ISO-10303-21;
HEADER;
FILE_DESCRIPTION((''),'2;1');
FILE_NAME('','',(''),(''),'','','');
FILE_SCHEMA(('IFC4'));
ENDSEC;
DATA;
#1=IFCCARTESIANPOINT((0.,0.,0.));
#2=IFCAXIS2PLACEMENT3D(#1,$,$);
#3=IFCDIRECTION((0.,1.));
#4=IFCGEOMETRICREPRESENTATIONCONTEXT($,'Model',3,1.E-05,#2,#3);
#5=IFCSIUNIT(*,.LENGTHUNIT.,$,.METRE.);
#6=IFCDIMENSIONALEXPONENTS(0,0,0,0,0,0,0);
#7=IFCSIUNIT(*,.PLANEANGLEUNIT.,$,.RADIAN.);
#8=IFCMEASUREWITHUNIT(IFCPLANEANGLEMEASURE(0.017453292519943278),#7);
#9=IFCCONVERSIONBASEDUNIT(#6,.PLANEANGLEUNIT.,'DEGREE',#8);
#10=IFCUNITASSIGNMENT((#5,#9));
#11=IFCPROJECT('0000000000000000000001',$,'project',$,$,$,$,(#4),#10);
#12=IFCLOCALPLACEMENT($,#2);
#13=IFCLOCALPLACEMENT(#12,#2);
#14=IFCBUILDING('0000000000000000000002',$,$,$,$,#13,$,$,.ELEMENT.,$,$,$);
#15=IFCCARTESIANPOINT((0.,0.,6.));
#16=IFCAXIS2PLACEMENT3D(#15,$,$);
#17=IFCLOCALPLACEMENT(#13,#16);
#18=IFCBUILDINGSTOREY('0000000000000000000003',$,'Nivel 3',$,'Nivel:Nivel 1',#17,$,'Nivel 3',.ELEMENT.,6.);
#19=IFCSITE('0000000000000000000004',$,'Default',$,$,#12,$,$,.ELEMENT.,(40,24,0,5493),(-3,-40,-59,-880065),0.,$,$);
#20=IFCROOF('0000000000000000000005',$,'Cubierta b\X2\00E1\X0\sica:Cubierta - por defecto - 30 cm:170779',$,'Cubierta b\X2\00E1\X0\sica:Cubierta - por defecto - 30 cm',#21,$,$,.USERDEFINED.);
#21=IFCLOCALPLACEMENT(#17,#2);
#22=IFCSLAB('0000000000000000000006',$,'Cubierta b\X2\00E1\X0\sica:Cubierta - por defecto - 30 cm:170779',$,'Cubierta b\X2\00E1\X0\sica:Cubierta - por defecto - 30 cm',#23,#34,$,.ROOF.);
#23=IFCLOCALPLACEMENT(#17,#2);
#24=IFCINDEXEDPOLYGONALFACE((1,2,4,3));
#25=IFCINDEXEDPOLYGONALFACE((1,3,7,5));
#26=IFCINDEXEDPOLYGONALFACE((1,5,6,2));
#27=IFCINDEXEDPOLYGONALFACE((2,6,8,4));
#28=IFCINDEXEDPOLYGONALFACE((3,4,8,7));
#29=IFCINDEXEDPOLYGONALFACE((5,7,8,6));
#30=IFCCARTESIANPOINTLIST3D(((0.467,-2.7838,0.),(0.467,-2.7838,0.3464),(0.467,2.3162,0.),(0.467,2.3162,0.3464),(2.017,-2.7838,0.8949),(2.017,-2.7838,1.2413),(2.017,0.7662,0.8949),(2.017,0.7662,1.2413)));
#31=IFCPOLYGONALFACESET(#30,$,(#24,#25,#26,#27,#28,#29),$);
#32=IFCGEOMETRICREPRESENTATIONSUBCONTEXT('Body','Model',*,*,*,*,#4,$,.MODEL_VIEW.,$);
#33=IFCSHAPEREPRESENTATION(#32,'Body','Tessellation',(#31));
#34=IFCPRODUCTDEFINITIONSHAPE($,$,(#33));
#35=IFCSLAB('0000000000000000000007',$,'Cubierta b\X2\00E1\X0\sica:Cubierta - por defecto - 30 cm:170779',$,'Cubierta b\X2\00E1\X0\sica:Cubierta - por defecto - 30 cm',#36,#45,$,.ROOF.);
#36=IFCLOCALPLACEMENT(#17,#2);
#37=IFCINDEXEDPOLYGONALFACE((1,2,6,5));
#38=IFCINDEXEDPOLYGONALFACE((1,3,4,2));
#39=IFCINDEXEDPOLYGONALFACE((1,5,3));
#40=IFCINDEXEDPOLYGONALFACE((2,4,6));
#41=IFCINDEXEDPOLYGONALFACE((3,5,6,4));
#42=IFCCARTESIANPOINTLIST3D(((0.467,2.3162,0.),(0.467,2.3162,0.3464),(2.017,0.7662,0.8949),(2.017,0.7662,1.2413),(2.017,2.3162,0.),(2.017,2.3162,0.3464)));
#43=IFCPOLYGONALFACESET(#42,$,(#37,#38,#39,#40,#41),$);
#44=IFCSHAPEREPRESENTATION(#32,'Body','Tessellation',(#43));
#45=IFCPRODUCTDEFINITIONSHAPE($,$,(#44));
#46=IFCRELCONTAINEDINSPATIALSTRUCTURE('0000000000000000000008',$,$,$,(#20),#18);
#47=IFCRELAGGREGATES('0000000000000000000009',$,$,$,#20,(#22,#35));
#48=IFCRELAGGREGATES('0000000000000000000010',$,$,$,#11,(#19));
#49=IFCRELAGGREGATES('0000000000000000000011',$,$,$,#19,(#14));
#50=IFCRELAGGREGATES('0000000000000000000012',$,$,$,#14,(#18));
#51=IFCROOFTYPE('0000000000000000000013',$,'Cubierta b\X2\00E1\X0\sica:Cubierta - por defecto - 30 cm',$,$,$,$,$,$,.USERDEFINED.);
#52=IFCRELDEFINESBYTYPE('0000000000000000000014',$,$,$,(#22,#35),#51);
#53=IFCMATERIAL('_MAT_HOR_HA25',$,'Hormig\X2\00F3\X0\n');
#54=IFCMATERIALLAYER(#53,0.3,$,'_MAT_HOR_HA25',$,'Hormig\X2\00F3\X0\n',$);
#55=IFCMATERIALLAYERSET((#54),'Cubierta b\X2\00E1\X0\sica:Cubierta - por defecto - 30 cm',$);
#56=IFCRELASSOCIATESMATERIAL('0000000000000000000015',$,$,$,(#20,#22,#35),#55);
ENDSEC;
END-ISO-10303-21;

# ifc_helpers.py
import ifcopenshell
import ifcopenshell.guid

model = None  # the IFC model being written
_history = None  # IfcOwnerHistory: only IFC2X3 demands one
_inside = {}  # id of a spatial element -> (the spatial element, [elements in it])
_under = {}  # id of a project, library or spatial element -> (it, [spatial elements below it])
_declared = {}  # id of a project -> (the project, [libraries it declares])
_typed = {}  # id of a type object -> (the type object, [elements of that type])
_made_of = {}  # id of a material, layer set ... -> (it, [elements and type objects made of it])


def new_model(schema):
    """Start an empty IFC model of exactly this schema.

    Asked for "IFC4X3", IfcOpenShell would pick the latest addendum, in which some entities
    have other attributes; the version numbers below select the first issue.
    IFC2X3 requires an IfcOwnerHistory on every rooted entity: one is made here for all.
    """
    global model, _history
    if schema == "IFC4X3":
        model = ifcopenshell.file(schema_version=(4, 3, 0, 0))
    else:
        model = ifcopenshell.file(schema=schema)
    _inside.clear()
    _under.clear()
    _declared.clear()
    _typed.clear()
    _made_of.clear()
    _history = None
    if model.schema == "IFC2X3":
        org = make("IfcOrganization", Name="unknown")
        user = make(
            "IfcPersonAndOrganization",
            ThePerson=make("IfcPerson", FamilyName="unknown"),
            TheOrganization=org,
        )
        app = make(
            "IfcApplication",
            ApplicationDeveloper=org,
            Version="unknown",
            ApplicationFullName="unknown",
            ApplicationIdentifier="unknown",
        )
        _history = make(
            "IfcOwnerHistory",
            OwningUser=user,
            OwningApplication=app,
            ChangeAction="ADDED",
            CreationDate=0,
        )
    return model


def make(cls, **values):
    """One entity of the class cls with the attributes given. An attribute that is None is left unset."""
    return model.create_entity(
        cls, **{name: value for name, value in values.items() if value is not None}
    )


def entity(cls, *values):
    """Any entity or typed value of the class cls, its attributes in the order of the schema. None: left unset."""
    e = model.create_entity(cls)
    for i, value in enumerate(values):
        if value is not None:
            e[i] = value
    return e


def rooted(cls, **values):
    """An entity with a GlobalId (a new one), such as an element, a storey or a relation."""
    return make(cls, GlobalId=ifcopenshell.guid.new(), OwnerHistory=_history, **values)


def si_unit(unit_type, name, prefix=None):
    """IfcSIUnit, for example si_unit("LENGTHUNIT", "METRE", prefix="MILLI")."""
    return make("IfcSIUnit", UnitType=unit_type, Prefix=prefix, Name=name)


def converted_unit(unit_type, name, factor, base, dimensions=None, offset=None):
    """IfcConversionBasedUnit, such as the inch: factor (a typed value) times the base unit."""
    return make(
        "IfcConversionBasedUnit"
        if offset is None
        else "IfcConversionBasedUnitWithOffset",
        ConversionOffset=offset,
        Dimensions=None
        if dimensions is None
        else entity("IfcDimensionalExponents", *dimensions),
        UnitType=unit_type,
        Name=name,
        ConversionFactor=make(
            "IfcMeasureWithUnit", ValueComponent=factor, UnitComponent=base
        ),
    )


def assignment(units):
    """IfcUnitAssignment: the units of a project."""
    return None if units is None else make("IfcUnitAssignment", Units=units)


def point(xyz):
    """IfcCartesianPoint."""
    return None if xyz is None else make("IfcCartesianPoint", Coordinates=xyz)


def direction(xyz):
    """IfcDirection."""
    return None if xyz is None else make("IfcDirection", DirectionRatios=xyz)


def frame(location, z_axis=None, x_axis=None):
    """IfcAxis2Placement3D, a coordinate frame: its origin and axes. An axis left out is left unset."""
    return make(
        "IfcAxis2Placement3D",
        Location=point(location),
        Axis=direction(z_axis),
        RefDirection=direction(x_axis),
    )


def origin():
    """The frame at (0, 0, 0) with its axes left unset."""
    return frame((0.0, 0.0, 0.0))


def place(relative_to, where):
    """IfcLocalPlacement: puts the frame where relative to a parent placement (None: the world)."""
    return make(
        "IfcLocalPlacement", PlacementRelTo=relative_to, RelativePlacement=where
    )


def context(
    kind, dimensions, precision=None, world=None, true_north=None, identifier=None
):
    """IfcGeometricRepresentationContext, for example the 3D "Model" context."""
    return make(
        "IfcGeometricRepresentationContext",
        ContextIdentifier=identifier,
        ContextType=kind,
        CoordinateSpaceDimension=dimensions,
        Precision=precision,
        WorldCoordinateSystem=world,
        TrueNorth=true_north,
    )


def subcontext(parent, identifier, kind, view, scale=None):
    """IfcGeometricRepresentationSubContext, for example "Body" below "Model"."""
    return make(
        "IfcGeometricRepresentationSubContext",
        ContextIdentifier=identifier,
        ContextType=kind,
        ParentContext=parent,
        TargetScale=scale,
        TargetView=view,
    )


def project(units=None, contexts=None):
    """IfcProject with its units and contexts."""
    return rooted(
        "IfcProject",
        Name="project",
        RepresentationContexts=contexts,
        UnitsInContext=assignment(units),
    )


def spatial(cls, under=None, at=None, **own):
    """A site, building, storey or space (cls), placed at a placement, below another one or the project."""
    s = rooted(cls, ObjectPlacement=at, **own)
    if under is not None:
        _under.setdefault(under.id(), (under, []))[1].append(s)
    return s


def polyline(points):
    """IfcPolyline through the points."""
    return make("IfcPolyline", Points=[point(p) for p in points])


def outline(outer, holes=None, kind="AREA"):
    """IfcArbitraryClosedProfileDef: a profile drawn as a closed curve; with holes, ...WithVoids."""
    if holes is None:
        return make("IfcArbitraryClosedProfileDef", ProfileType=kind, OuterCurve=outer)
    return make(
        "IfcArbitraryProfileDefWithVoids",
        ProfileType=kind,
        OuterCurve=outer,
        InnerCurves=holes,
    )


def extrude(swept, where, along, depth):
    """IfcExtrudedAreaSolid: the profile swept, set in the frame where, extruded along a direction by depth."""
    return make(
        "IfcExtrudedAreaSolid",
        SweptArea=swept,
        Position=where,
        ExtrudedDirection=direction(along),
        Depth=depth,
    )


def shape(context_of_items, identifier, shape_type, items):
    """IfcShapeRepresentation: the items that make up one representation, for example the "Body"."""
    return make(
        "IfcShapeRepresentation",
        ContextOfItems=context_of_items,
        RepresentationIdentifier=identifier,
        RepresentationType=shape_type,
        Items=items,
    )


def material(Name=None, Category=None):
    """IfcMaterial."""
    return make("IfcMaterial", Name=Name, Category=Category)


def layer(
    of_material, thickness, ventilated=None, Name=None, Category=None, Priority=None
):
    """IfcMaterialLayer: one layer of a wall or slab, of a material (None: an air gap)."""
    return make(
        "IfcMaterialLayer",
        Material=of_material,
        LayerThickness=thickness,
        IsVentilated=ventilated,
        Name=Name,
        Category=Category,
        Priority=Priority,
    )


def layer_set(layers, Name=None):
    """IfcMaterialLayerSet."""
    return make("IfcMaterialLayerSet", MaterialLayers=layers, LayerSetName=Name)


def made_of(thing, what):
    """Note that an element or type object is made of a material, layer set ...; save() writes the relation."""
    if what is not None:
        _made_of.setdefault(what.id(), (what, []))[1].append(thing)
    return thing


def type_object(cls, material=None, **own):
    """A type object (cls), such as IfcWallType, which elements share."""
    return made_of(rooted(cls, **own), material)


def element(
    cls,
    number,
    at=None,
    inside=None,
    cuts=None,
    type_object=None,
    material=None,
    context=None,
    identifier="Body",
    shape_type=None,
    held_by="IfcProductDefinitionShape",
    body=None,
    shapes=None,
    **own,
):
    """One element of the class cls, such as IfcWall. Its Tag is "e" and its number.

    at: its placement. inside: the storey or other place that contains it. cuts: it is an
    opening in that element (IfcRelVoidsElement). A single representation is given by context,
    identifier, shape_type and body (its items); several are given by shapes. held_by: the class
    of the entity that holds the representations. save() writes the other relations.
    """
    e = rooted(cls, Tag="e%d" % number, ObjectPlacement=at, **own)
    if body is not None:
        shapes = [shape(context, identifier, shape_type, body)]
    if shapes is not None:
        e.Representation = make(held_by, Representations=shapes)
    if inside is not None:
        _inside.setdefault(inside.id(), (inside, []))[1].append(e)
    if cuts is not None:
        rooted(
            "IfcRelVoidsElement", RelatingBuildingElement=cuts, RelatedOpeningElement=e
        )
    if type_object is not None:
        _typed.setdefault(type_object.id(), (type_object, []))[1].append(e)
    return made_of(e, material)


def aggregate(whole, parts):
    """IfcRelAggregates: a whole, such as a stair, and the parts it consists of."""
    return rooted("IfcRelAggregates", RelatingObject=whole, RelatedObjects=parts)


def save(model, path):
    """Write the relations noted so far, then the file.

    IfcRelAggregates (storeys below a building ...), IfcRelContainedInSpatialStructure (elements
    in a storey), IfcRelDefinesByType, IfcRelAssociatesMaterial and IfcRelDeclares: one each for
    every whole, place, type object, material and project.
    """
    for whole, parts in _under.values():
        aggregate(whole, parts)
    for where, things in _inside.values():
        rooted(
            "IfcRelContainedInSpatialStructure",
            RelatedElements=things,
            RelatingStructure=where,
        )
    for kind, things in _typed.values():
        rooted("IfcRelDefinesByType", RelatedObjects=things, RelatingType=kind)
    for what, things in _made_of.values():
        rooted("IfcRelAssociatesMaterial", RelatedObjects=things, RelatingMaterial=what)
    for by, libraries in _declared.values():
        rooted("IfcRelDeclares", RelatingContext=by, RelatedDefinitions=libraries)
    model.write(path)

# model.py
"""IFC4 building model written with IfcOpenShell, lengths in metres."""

from ifc_helpers import new_model, entity, si_unit, converted_unit, direction, frame, origin, place, context, subcontext, project, spatial, polyline, outline, extrude, material, layer, layer_set, type_object, element, aggregate, save


model = new_model("IFC4")

# Units and contexts
model_context = context("Model", 3, precision=1e-05, world=origin(), true_north=direction((0.0, 1.0)))
body_context = subcontext(model_context, "Body", "Model", "MODEL_VIEW")
ifc_project = project(units=[si_unit("LENGTHUNIT", "METRE"), converted_unit("PLANEANGLEUNIT", "DEGREE", entity("IfcPlaneAngleMeasure", 0.017453292519943278), si_unit("PLANEANGLEUNIT", "RADIAN"), dimensions=[0, 0, 0, 0, 0, 0, 0])], contexts=[model_context])

# Site, building, storey
site_placement = place(None, origin())
site = spatial("IfcSite", under=ifc_project, at=site_placement, Name="Default", CompositionType="ELEMENT", RefLatitude=(40, 24, 0, 5493), RefLongitude=(-3, -40, -59, -880065), RefElevation=0.0)
building_placement = place(site_placement, origin())
building = spatial("IfcBuilding", under=site, at=building_placement, CompositionType="ELEMENT")
storey_placement = place(building_placement, frame((0.0, 0.0, 6.0)))
storey = spatial("IfcBuildingStorey", under=building, at=storey_placement, Name="Nivel 3", ObjectType="Nivel:Nivel 1", LongName="Nivel 3", CompositionType="ELEMENT", Elevation=6.0)

# Roof, slabs
ifc_material = material(Name="_MAT_HOR_HA25", Category="Hormigón")
ifc_layer = layer(ifc_material, 0.3, Name="_MAT_HOR_HA25", Category="Hormigón")
ifc_layer_set = layer_set([ifc_layer], Name="Cubierta básica:Cubierta - por defecto - 30 cm")
roof_placement = place(storey_placement, frame((0.467, -2.7838, 0.0)))
roof = element("IfcRoof", 1, at=roof_placement, inside=storey, material=ifc_layer_set, Name="Cubierta básica:Cubierta - por defecto - 30 cm:170779", ObjectType="Cubierta básica:Cubierta - por defecto - 30 cm", PredefinedType="USERDEFINED")
roof_type = type_object("IfcRoofType", Name="Cubierta básica:Cubierta - por defecto - 30 cm", PredefinedType="USERDEFINED")
slab_1_placement = place(roof_placement, origin())
slab_1 = element("IfcSlab", 2, at=slab_1_placement, type_object=roof_type, material=ifc_layer_set, Name="Cubierta básica:Cubierta - por defecto - 30 cm:170779", ObjectType="Cubierta básica:Cubierta - por defecto - 30 cm", PredefinedType="ROOF", context=body_context, shape_type="SweptSolid", body=[
    extrude(outline(polyline([(0.8949, 1.0), (-0.8949, 2.55), (-0.8949, -2.55), (0.8949, -2.55), (0.8949, 1.0)])), frame((0.775, 2.55, 0.4474), z_axis=(-0.5, 0.0, 0.866025), x_axis=(0.866025, 0.0, 0.5)), (0.5, 0.0, 0.866025), 0.3464),
])
slab_2_placement = place(roof_placement, origin())
slab_2 = element("IfcSlab", 3, at=slab_2_placement, type_object=roof_type, material=ifc_layer_set, Name="Cubierta básica:Cubierta - por defecto - 30 cm:170779", ObjectType="Cubierta básica:Cubierta - por defecto - 30 cm", PredefinedType="ROOF", context=body_context, shape_type="SweptSolid", body=[
    extrude(outline(polyline([(-0.775, 0.8949), (0.775, -0.8949), (0.775, 0.8949), (-0.775, 0.8949)])), frame((0.775, 4.325, 0.4474), z_axis=(0.0, 0.5, 0.866025), x_axis=(1.0, 0.0, 0.0)), (0.0, -0.5, 0.866025), 0.3464),
])
aggregate(roof, [slab_1, slab_2])

save(model, "model.ifc")
